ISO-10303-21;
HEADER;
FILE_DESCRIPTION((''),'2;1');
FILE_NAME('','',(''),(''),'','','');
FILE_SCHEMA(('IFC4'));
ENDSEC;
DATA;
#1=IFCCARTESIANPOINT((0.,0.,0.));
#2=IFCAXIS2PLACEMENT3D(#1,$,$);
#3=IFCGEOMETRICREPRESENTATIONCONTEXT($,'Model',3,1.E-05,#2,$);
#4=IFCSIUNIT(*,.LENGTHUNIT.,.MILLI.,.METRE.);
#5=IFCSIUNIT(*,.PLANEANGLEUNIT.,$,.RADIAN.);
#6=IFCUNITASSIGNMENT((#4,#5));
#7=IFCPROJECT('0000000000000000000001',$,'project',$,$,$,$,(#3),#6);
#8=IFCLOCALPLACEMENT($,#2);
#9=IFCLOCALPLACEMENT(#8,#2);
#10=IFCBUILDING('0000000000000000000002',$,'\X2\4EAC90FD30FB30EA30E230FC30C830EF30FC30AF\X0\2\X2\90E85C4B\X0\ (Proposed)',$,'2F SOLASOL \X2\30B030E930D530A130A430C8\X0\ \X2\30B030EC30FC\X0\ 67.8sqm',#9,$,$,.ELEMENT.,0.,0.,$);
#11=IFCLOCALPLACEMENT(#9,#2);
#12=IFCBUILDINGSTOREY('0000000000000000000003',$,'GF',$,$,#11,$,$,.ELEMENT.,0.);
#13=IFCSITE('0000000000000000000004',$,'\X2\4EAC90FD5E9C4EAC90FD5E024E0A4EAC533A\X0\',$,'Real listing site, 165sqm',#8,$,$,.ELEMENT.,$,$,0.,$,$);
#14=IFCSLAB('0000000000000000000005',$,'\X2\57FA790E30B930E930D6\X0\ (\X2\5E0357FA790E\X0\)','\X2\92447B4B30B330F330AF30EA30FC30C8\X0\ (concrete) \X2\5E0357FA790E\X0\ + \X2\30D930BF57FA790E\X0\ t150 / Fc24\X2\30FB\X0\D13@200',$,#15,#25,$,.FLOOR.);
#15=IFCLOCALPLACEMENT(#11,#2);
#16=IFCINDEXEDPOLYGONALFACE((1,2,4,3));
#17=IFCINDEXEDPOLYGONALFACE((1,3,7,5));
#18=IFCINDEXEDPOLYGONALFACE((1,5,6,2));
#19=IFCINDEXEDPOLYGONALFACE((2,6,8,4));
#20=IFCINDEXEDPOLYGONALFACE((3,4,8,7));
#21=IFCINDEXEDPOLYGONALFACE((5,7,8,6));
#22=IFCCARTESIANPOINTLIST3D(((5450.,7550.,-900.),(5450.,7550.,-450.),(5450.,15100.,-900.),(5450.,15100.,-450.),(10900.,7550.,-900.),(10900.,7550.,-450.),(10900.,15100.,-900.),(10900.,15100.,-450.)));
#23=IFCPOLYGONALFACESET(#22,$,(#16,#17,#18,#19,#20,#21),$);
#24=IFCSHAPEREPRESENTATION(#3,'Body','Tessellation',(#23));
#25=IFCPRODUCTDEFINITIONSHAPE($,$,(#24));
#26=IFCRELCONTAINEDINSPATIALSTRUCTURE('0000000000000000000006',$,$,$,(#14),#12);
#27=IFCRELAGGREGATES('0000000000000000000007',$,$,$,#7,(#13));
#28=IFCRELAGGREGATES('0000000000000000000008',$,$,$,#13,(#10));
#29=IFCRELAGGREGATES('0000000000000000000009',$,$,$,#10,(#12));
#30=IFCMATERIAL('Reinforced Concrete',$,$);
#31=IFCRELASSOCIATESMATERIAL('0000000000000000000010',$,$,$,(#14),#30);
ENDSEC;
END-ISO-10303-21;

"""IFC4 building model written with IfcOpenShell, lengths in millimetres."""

from ifc_helpers import new_model, si_unit, frame, frame_2d, origin, place, context, project, spatial, rectangle, extrude, material, element, save


model = new_model("IFC4")

# Units and contexts
model_context = context("Model", 3, precision=1e-05, world=origin())
ifc_project = project(units=[si_unit("LENGTHUNIT", "METRE", prefix="MILLI"), si_unit("PLANEANGLEUNIT", "RADIAN")], contexts=[model_context])

# Site, building, storey
site_placement = place(None, origin())
site = spatial("IfcSite", under=ifc_project, at=site_placement, Name="京都府京都市上京区", ObjectType="Real listing site, 165sqm", CompositionType="ELEMENT", RefElevation=0.0)
building_placement = place(site_placement, origin())
building = spatial("IfcBuilding", under=site, at=building_placement, Name="京都・リモートワーク2部屋 (Proposed)", ObjectType="2F SOLASOL グラファイト グレー 67.8sqm", CompositionType="ELEMENT", ElevationOfRefHeight=0.0, ElevationOfTerrain=0.0)
storey_placement = place(building_placement, origin())
storey = spatial("IfcBuildingStorey", under=building, at=storey_placement, Name="GF", CompositionType="ELEMENT", Elevation=0.0)

# Slab
ifc_material_1 = material(Name="Reinforced Concrete")
slab_1_placement = place(storey_placement, frame((2725.0, 3775.0, -450.0)))
element("IfcSlab", 1, at=slab_1_placement, inside=storey, material=ifc_material_1, Name="基礎スラブ (布基礎)", Description="鉄筋コンクリート (concrete) 布基礎 + ベタ基礎 t150 / Fc24・D13@200", PredefinedType="FLOOR", context=model_context, shape_type="SweptSolid", body=[
    extrude(rectangle(XDim=5450.0, YDim=7550.0, at=frame_2d((2725.0, 3775.0))), frame((2725.0, 3775.0, -450.0)), (0.0, 0.0, 1.0), 450.0),
])

save(model, "model.ifc")
